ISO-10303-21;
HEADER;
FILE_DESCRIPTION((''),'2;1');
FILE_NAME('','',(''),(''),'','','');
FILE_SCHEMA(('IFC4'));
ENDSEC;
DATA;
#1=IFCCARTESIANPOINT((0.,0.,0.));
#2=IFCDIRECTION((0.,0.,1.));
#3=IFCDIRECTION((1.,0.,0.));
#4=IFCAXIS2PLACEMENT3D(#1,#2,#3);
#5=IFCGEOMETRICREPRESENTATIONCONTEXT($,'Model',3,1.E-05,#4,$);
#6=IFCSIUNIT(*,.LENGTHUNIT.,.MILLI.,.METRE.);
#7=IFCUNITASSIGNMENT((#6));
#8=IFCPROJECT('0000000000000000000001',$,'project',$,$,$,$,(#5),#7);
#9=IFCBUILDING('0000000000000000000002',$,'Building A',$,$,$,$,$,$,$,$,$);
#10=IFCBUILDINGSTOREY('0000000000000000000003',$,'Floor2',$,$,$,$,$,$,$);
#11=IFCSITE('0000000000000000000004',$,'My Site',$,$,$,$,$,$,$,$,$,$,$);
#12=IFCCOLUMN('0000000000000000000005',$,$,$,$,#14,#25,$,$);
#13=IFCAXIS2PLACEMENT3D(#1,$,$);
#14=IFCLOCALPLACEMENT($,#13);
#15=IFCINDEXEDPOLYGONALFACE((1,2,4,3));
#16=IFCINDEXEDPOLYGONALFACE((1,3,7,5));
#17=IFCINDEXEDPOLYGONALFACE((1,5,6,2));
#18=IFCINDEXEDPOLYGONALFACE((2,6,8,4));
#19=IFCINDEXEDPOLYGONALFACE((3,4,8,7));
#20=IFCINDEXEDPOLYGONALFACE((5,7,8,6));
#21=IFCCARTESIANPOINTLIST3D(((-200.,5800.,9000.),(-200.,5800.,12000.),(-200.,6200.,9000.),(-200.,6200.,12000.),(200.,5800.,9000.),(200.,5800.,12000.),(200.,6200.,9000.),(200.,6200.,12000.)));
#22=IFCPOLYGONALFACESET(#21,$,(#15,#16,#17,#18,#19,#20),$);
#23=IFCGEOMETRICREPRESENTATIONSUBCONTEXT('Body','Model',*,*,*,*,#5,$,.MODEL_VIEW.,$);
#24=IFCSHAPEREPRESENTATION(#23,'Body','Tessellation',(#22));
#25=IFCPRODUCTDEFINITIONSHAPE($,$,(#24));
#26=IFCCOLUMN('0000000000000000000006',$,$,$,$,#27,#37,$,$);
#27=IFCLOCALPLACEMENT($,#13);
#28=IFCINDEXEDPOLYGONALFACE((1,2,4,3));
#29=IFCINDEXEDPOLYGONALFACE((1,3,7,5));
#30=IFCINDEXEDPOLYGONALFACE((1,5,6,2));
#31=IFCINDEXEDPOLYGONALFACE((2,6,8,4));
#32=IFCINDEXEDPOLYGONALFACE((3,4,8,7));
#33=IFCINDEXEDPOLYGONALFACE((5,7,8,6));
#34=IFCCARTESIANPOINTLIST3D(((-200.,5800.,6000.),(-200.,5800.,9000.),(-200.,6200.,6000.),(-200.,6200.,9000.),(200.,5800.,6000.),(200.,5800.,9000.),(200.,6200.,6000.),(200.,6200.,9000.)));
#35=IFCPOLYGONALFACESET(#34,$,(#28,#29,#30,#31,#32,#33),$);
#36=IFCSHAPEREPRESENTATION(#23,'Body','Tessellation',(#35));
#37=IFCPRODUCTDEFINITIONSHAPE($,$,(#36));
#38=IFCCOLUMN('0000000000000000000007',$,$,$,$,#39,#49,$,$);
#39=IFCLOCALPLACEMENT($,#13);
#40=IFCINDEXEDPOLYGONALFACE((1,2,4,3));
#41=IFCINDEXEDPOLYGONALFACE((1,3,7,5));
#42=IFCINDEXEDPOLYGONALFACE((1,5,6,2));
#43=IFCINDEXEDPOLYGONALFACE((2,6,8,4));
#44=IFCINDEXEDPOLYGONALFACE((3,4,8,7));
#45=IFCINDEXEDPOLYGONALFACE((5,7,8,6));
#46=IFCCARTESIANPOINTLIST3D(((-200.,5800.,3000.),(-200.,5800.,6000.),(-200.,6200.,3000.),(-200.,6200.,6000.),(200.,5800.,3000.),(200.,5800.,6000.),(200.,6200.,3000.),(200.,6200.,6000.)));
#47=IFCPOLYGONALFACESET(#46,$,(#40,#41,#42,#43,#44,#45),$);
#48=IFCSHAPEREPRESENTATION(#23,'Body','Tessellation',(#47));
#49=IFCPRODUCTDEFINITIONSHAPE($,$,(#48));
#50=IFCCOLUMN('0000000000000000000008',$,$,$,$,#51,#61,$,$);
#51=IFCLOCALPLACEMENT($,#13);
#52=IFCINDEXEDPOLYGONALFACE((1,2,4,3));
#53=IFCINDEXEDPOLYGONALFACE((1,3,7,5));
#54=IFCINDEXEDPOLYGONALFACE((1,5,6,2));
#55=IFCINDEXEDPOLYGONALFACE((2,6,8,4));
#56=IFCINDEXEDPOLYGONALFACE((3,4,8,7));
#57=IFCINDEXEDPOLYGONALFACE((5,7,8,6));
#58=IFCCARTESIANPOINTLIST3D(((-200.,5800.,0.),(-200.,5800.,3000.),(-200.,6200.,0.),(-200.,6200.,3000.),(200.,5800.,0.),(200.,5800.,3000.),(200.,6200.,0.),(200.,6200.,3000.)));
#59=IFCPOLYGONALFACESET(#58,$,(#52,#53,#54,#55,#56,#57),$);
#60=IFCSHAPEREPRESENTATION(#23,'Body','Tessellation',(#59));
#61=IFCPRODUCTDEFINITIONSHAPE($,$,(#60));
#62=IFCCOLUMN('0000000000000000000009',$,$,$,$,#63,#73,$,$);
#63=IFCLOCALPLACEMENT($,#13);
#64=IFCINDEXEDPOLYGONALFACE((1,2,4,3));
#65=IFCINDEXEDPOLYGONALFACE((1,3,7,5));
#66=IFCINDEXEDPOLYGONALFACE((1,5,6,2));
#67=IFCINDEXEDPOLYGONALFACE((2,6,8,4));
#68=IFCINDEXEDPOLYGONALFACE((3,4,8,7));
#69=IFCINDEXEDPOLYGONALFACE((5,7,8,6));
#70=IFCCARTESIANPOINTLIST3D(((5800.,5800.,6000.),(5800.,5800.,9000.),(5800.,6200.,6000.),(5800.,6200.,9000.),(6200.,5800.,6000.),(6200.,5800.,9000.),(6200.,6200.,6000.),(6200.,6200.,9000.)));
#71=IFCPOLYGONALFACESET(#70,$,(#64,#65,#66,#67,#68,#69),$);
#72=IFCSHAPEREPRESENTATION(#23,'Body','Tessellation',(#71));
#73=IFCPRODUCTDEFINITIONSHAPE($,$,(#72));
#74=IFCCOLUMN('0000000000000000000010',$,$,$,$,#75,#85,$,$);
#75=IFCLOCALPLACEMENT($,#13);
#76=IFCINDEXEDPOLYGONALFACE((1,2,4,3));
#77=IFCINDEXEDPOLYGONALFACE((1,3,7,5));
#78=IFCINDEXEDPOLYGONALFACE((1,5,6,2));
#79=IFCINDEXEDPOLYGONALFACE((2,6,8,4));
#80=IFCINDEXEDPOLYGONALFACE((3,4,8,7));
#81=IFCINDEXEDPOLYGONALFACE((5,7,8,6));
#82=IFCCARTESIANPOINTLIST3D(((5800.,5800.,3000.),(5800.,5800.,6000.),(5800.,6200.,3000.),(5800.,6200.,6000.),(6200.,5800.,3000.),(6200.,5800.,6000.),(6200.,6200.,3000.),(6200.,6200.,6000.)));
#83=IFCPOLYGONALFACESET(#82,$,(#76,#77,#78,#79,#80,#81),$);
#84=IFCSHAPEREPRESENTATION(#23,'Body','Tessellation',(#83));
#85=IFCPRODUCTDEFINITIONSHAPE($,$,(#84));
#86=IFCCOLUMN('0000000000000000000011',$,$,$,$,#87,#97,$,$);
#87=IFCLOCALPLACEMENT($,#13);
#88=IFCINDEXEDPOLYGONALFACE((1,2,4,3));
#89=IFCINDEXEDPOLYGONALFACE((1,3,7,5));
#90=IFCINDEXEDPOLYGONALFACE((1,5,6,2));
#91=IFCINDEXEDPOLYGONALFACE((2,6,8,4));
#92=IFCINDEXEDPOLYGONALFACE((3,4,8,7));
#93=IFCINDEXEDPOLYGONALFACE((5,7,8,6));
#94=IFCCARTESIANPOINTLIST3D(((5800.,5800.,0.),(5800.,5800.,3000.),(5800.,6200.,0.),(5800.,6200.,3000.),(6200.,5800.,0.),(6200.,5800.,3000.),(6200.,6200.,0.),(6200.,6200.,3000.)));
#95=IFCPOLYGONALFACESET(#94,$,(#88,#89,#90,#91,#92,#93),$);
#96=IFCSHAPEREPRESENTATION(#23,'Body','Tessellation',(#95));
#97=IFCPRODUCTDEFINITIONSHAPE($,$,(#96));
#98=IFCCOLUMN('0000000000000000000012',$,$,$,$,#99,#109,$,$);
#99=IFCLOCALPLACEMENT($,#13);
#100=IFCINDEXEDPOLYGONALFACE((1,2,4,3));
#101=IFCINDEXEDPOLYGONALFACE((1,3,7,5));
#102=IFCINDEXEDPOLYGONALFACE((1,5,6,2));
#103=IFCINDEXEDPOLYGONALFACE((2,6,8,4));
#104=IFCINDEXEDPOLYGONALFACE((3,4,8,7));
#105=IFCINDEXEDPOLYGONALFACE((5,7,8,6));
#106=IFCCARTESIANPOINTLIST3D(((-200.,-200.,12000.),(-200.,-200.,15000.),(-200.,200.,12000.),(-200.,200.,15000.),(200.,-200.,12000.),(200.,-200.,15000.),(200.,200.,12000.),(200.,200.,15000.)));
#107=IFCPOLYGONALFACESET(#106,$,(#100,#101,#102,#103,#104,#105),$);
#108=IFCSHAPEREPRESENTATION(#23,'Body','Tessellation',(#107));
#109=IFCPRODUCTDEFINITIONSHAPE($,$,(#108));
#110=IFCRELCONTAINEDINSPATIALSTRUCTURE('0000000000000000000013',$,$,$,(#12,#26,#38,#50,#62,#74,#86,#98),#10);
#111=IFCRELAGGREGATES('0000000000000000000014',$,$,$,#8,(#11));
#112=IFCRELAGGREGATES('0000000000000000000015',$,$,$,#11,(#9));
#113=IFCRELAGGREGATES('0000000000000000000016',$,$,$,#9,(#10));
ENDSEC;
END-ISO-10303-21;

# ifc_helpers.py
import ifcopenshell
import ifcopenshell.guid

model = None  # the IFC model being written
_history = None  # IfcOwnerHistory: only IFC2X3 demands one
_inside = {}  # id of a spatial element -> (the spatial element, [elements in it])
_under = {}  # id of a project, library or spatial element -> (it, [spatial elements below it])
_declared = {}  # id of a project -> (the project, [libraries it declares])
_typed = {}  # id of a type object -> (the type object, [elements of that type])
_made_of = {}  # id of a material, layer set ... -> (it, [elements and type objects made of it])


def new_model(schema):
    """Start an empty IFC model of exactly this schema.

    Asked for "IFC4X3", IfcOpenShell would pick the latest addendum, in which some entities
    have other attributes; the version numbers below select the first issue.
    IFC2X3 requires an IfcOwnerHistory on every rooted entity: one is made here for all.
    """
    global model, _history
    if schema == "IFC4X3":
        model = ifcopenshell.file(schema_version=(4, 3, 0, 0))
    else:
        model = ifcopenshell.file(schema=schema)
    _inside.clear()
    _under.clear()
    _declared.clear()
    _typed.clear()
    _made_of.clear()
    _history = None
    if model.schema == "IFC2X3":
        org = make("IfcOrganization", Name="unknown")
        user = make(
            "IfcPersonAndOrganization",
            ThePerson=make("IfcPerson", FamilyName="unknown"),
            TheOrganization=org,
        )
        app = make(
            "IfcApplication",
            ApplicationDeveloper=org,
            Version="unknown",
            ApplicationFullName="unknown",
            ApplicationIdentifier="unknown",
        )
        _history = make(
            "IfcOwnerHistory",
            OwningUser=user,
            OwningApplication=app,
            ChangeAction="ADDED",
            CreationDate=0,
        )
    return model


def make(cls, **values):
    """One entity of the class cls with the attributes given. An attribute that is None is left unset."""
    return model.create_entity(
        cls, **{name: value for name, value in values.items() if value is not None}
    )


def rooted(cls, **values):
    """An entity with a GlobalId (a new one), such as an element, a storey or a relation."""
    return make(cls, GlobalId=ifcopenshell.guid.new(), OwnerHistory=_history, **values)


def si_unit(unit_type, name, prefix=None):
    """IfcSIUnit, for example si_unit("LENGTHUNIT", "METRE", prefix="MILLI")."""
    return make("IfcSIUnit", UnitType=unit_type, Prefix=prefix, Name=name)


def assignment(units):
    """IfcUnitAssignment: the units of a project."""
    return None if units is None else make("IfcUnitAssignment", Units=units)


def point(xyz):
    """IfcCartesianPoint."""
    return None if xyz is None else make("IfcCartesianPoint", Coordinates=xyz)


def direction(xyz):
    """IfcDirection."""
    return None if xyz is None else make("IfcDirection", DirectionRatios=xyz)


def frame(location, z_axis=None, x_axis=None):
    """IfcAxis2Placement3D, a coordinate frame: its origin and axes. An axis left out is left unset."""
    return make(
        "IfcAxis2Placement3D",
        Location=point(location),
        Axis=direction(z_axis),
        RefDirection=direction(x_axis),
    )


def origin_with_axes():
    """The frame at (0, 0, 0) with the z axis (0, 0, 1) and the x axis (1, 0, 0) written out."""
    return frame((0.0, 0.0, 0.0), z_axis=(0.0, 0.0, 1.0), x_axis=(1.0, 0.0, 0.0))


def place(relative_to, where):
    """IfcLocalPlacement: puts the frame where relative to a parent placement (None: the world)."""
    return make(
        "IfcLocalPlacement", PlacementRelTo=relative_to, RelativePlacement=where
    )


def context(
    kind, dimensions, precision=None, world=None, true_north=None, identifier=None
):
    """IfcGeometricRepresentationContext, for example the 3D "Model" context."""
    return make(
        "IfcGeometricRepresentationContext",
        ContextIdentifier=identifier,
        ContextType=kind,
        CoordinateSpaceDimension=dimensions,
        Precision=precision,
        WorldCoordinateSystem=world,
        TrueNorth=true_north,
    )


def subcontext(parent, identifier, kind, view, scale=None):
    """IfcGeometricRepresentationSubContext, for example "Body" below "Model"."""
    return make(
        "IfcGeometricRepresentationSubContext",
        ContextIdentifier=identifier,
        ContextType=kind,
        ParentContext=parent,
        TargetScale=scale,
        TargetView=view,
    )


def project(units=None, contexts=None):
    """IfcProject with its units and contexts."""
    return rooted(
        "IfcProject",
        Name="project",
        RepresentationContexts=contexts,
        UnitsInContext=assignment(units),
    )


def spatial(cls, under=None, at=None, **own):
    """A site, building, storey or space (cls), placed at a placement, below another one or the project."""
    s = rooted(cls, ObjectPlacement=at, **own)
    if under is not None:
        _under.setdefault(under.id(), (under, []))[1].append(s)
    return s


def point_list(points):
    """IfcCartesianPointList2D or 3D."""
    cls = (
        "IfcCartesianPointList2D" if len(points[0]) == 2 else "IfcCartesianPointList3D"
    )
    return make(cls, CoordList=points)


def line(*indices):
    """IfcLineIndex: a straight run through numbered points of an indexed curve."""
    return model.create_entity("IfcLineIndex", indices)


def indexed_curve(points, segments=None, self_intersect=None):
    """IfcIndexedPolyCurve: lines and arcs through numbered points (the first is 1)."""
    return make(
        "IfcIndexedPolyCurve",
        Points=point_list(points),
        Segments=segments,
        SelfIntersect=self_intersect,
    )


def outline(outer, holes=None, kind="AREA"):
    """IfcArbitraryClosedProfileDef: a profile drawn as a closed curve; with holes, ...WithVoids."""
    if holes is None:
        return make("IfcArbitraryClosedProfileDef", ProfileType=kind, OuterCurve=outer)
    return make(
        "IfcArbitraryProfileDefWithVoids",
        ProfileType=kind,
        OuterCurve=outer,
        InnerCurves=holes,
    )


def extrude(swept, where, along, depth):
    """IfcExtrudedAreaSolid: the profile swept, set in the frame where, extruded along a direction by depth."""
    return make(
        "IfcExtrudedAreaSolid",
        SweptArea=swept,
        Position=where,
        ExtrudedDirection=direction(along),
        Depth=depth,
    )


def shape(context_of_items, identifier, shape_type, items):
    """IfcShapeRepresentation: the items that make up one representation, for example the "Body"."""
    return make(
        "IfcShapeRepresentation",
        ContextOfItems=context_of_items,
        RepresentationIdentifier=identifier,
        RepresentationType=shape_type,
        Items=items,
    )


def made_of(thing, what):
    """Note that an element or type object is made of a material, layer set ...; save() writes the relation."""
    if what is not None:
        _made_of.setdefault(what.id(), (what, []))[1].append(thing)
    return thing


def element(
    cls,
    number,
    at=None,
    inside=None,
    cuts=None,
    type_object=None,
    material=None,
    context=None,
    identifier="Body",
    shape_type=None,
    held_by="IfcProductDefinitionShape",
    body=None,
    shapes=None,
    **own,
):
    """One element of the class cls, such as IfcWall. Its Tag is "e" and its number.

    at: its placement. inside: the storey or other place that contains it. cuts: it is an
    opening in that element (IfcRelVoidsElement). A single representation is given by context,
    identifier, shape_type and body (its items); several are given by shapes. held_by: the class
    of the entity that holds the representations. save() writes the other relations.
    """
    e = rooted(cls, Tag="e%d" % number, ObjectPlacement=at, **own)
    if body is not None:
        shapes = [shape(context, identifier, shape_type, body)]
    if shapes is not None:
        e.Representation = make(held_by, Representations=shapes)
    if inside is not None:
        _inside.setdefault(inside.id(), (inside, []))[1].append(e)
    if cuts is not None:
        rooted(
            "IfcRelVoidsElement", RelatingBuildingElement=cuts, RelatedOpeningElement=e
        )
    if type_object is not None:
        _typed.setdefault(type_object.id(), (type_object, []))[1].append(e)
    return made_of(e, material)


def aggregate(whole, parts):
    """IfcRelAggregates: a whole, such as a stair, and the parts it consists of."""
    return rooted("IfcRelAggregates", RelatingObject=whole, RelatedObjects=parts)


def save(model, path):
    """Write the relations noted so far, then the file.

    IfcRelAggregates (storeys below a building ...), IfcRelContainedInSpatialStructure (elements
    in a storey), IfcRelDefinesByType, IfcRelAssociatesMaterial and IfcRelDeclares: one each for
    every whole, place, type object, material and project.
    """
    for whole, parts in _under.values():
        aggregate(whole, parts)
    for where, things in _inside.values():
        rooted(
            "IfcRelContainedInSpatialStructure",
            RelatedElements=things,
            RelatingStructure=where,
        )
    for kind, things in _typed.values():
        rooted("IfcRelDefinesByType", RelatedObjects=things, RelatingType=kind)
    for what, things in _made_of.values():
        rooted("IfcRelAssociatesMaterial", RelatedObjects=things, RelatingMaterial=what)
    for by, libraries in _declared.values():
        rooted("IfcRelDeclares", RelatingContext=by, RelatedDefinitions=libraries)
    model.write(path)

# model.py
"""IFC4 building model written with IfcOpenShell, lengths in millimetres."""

from ifc_helpers import new_model, si_unit, frame, origin_with_axes, place, context, subcontext, project, spatial, line, indexed_curve, outline, extrude, element, save


model = new_model("IFC4")

# Units and contexts
model_context = context("Model", 3, precision=1e-05, world=origin_with_axes())
body_context = subcontext(model_context, "Body", "Model", "MODEL_VIEW")
ifc_project = project(units=[si_unit("LENGTHUNIT", "METRE", prefix="MILLI")], contexts=[model_context])

# Site, building, storey
site = spatial("IfcSite", under=ifc_project, Name="My Site")
building = spatial("IfcBuilding", under=site, Name="Building A")
storey = spatial("IfcBuildingStorey", under=building, Name="Floor2")

# Columns
for number, where, z_axis, x_axis in (
    (1, (0.0, 6000.0, 9000.0), (0.0, 0.0, 1.0), (1.0, 0.0, 0.0)),
    (2, (0.0, 6000.0, 6000.0), (0.0, 0.0, 1.0), (1.0, 0.0, 0.0)),
    (3, (0.0, 6000.0, 3000.0), (0.0, 0.0, 1.0), (1.0, 0.0, 0.0)),
    (4, (0.0, 6000.0, 0.0), (0.0, 0.0, 1.0), (1.0, 0.0, 0.0)),
    (5, (6000.0, 6000.0, 6000.0), (0.0, 0.0, 1.0), (1.0, 0.0, 0.0)),
    (6, (6000.0, 6000.0, 3000.0), (0.0, 0.0, 1.0), (1.0, 0.0, 0.0)),
    (7, (6000.0, 6000.0, 0.0), (0.0, 0.0, 1.0), (1.0, 0.0, 0.0)),
    (8, (0.0, 0.0, 12000.0), (0.0, 0.0, 1.0), (1.0, 0.0, 0.0)),
):
    element("IfcColumn", number, at=place(None, frame(where, z_axis=z_axis, x_axis=x_axis)), inside=storey, context=body_context, shape_type="SweptSolid", body=[
        extrude(outline(indexed_curve([(-200.0, -200.0), (200.0, -200.0), (200.0, 200.0), (-200.0, 200.0)], segments=[line(1, 2, 3, 4, 1)])), origin_with_axes(), (0.0, 0.0, 1.0), 3000.0),
    ])

save(model, "model.ifc")
